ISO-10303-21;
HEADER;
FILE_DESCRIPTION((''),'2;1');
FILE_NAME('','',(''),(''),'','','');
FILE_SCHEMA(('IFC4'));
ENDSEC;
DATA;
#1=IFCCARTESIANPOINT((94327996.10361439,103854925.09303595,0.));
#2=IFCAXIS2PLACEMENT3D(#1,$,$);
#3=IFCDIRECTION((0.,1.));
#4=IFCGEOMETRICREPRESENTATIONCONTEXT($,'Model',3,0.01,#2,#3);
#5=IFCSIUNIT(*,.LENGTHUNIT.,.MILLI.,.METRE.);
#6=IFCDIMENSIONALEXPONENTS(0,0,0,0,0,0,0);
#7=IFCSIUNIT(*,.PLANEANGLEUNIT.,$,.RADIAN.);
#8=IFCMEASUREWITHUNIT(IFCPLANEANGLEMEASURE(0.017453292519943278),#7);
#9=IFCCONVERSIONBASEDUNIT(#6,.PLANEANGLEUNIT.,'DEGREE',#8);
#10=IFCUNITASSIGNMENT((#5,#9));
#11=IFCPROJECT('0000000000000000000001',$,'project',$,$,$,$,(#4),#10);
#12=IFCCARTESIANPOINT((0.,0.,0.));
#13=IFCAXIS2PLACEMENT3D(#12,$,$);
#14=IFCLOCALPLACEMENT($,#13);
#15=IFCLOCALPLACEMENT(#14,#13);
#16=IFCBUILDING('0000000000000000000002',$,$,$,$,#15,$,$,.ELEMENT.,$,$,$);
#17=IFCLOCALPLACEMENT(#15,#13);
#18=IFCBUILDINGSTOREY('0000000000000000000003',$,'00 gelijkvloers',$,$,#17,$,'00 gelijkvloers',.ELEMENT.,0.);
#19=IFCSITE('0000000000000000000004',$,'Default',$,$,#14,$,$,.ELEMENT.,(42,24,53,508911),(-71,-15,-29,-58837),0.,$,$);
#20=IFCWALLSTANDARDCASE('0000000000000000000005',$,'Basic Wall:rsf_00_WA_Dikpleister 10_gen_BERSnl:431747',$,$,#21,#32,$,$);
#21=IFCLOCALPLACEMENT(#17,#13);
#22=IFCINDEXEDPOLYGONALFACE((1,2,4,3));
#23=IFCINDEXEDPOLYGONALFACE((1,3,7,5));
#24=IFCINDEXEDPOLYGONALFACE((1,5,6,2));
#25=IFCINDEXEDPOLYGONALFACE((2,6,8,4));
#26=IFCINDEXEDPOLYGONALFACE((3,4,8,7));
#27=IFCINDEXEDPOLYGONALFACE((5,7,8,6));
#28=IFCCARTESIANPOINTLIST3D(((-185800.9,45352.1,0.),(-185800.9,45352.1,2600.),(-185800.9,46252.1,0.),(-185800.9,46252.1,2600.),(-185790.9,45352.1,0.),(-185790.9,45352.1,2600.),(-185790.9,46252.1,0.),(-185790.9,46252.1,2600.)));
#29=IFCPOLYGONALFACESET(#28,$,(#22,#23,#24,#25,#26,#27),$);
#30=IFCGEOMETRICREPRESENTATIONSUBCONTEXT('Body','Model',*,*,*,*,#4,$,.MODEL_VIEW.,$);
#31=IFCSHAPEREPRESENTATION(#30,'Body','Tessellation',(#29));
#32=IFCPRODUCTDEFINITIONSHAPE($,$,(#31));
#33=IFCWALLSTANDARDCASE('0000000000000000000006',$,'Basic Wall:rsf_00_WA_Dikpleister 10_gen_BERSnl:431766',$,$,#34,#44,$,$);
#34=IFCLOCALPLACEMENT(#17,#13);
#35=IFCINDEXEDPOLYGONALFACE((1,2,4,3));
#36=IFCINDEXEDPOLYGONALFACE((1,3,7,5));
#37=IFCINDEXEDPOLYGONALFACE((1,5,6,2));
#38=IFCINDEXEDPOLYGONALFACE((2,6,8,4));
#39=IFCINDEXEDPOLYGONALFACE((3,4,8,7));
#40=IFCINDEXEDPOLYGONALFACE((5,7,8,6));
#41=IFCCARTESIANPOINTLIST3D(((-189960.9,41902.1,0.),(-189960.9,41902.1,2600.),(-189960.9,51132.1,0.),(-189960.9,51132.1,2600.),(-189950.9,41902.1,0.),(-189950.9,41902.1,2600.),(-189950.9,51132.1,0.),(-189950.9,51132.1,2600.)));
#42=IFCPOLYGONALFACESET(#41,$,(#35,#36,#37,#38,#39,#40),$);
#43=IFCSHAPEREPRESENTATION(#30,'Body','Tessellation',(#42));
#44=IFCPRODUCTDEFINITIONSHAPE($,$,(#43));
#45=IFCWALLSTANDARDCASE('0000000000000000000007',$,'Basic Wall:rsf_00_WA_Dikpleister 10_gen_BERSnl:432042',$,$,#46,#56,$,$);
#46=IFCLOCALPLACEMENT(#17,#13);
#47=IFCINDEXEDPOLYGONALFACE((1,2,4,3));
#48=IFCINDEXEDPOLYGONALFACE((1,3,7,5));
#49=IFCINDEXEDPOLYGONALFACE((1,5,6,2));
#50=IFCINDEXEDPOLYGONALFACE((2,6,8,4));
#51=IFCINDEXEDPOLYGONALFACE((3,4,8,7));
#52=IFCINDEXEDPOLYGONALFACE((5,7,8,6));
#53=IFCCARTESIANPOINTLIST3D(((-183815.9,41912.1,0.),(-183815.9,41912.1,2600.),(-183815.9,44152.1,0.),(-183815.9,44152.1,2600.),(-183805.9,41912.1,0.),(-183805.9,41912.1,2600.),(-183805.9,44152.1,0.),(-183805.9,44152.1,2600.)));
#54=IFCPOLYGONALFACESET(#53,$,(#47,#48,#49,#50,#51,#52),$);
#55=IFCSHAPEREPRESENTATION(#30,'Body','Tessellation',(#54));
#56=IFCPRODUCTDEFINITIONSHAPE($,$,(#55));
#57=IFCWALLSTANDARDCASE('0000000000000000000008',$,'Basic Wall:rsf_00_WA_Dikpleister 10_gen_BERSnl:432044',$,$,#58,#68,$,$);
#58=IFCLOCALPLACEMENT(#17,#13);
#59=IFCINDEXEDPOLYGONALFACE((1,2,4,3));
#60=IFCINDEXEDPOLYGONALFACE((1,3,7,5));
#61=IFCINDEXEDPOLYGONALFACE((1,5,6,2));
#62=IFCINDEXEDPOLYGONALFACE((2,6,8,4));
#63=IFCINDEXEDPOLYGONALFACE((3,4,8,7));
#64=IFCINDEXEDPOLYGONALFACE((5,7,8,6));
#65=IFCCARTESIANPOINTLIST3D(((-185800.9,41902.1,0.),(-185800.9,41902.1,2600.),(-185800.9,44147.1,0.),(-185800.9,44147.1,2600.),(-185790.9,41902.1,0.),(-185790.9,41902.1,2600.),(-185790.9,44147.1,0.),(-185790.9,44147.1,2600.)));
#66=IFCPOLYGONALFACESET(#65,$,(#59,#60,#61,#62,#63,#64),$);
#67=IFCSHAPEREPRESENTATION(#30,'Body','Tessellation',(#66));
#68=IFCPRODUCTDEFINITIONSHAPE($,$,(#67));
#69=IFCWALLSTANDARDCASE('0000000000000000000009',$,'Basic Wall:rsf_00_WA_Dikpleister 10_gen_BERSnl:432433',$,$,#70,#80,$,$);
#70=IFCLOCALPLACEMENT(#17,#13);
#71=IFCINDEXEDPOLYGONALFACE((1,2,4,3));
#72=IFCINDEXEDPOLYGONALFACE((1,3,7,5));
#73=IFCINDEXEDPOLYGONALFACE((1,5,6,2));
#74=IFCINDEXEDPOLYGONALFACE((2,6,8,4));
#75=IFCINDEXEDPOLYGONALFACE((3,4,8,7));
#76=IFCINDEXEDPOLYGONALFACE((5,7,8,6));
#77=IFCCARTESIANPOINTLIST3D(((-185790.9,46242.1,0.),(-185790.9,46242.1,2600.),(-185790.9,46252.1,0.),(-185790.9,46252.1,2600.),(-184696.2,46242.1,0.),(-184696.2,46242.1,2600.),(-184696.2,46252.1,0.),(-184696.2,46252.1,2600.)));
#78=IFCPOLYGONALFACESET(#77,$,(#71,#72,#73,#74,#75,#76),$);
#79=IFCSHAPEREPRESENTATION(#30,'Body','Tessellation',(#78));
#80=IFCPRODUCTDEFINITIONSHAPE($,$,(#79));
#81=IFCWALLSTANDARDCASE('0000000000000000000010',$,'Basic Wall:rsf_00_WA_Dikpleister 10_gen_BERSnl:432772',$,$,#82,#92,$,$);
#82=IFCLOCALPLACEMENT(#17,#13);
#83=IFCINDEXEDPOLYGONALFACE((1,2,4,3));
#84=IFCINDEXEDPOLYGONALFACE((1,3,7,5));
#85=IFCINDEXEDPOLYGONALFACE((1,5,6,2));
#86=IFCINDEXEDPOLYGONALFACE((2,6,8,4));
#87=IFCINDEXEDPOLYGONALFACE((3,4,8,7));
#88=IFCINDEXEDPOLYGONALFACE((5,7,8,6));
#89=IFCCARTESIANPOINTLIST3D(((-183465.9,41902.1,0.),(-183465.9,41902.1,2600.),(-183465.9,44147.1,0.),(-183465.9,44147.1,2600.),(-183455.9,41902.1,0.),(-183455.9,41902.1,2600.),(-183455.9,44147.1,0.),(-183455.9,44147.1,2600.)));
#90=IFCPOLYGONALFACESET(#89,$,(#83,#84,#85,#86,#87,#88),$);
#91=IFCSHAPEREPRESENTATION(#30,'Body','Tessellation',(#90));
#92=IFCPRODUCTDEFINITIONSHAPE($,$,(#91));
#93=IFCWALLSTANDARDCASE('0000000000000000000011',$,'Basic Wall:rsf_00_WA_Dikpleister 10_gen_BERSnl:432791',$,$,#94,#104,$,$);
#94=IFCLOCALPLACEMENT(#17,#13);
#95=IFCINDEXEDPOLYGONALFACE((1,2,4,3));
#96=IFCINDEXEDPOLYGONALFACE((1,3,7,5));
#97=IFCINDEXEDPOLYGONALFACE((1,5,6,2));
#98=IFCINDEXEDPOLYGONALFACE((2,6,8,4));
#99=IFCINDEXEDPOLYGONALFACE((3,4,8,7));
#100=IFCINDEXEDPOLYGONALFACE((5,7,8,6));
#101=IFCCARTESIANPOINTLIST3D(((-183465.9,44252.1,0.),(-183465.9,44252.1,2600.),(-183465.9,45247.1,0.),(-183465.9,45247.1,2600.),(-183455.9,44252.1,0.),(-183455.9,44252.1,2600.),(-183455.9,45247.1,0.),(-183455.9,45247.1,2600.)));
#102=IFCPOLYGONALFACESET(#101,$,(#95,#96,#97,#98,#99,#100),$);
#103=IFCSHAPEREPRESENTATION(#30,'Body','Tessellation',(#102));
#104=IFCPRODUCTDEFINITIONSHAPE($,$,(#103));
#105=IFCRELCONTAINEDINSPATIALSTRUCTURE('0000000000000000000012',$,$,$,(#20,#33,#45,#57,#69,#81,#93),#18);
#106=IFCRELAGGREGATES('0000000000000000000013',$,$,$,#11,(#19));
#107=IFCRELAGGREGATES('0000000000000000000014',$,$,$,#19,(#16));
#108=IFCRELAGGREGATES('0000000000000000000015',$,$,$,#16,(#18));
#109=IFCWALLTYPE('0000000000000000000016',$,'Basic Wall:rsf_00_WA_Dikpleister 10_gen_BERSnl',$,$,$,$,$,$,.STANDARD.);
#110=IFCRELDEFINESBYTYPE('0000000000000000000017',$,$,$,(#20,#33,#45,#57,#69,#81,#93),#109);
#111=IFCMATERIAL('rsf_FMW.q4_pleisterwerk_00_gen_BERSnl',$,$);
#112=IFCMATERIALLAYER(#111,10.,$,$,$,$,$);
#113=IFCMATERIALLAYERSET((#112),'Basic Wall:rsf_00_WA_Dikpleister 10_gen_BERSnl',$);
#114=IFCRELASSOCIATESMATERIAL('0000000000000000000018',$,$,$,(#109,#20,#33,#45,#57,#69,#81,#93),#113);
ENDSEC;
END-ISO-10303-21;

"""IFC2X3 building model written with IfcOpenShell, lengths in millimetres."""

from ifc_helpers import new_model, entity, si_unit, converted_unit, direction, frame, frame_2d, origin, place, context, subcontext, project, spatial, rectangle, extrude, material, layer, layer_set, layer_usage, type_object, element, save


model = new_model("IFC2X3")

# Units and contexts
model_context = context("Model", 3, precision=0.01, world=frame((94327996.10361439, 103854925.09303595, 0.0)), true_north=direction((0.0, 1.0)))
body_context = subcontext(model_context, "Body", "Model", "MODEL_VIEW")
ifc_project = project(units=[si_unit("LENGTHUNIT", "METRE", prefix="MILLI"), converted_unit("PLANEANGLEUNIT", "DEGREE", entity("IfcPlaneAngleMeasure", 0.017453292519943278), si_unit("PLANEANGLEUNIT", "RADIAN"), dimensions=[0, 0, 0, 0, 0, 0, 0])], contexts=[model_context])

# Site, building, storey
site_placement = place(None, origin())
site = spatial("IfcSite", under=ifc_project, at=site_placement, Name="Default", CompositionType="ELEMENT", RefLatitude=(42, 24, 53, 508911), RefLongitude=(-71, -15, -29, -58837), RefElevation=0.0)
building_placement = place(site_placement, origin())
building = spatial("IfcBuilding", under=site, at=building_placement, CompositionType="ELEMENT")
storey_placement = place(building_placement, origin())
storey = spatial("IfcBuildingStorey", under=building, at=storey_placement, Name="00 gelijkvloers", LongName="00 gelijkvloers", CompositionType="ELEMENT", Elevation=0.0)

# Shared definitions
ifc_material_1 = material(Name="rsf_FMW.q4_pleisterwerk_00_gen_BERSnl")

# Walls
ifc_layer_1 = layer(ifc_material_1, 10.0)
ifc_layer_set_1 = layer_set([ifc_layer_1], Name="Basic Wall:rsf_00_WA_Dikpleister 10_gen_BERSnl")
wall_type_1 = type_object("IfcWallType", Name="Basic Wall:rsf_00_WA_Dikpleister 10_gen_BERSnl", PredefinedType="STANDARD", material=ifc_layer_set_1)
ifc_layer_usage_1 = layer_usage(ifc_layer_set_1, "AXIS2", "POSITIVE", -5.0)
wall_1_placement = place(storey_placement, frame((-185795.9, 45352.1, 0.0), z_axis=(0.0, 0.0, 1.0), x_axis=(0.0, 1.0, 0.0)))
element("IfcWallStandardCase", 1, at=wall_1_placement, inside=storey, type_object=wall_type_1, material=ifc_layer_usage_1, Name="Basic Wall:rsf_00_WA_Dikpleister 10_gen_BERSnl:431747", context=body_context, shape_type="SweptSolid", body=[
    extrude(rectangle(XDim=900.0, YDim=10.0, at=frame_2d((450.0, 0.0), x_axis=(-1.0, 0.0))), origin(), (0.0, 0.0, 1.0), 2600.0),
])
ifc_layer_usage_2 = layer_usage(ifc_layer_set_1, "AXIS2", "POSITIVE", -5.0)
wall_2_placement = place(storey_placement, frame((-189955.9, 41902.1, 0.0), z_axis=(0.0, 0.0, 1.0), x_axis=(0.0, 1.0, 0.0)))
element("IfcWallStandardCase", 2, at=wall_2_placement, inside=storey, type_object=wall_type_1, material=ifc_layer_usage_2, Name="Basic Wall:rsf_00_WA_Dikpleister 10_gen_BERSnl:431766", context=body_context, shape_type="SweptSolid", body=[
    extrude(rectangle(XDim=9230.0, YDim=10.0, at=frame_2d((4615.0, 0.0), x_axis=(-1.0, 0.0))), origin(), (0.0, 0.0, 1.0), 2600.0),
])
ifc_layer_usage_3 = layer_usage(ifc_layer_set_1, "AXIS2", "POSITIVE", -5.0)
wall_3_placement = place(storey_placement, frame((-183810.9, 44152.1, 0.0), z_axis=(0.0, 0.0, 1.0), x_axis=(0.0, -1.0, 0.0)))
element("IfcWallStandardCase", 3, at=wall_3_placement, inside=storey, type_object=wall_type_1, material=ifc_layer_usage_3, Name="Basic Wall:rsf_00_WA_Dikpleister 10_gen_BERSnl:432042", context=body_context, shape_type="SweptSolid", body=[
    extrude(rectangle(XDim=2240.0, YDim=10.0, at=frame_2d((1120.0, 0.0), x_axis=(-1.0, 0.0))), origin(), (0.0, 0.0, 1.0), 2600.0),
])
ifc_layer_usage_4 = layer_usage(ifc_layer_set_1, "AXIS2", "POSITIVE", -5.0)
wall_4_placement = place(storey_placement, frame((-185795.9, 41902.1, 0.0), z_axis=(0.0, 0.0, 1.0), x_axis=(0.0, 1.0, 0.0)))
element("IfcWallStandardCase", 4, at=wall_4_placement, inside=storey, type_object=wall_type_1, material=ifc_layer_usage_4, Name="Basic Wall:rsf_00_WA_Dikpleister 10_gen_BERSnl:432044", context=body_context, shape_type="SweptSolid", body=[
    extrude(rectangle(XDim=2245.0, YDim=10.0, at=frame_2d((1122.5, 0.0), x_axis=(-1.0, 0.0))), origin(), (0.0, 0.0, 1.0), 2600.0),
])
ifc_layer_usage_5 = layer_usage(ifc_layer_set_1, "AXIS2", "POSITIVE", -5.0)
wall_5_placement = place(storey_placement, frame((-185790.9, 46247.1, 0.0)))
element("IfcWallStandardCase", 5, at=wall_5_placement, inside=storey, type_object=wall_type_1, material=ifc_layer_usage_5, Name="Basic Wall:rsf_00_WA_Dikpleister 10_gen_BERSnl:432433", context=body_context, shape_type="SweptSolid", body=[
    extrude(rectangle(XDim=1094.6, YDim=10.0, at=frame_2d((547.3, 0.0), x_axis=(-1.0, 0.0))), origin(), (0.0, 0.0, 1.0), 2600.0),
])
ifc_layer_usage_6 = layer_usage(ifc_layer_set_1, "AXIS2", "POSITIVE", -5.0)
wall_6_placement = place(storey_placement, frame((-183460.9, 41902.1, 0.0), z_axis=(0.0, 0.0, 1.0), x_axis=(0.0, 1.0, 0.0)))
element("IfcWallStandardCase", 6, at=wall_6_placement, inside=storey, type_object=wall_type_1, material=ifc_layer_usage_6, Name="Basic Wall:rsf_00_WA_Dikpleister 10_gen_BERSnl:432772", context=body_context, shape_type="SweptSolid", body=[
    extrude(rectangle(XDim=2245.0, YDim=10.0, at=frame_2d((1122.5, 0.0), x_axis=(-1.0, 0.0))), origin(), (0.0, 0.0, 1.0), 2600.0),
])
ifc_layer_usage_7 = layer_usage(ifc_layer_set_1, "AXIS2", "POSITIVE", -5.0)
wall_7_placement = place(storey_placement, frame((-183460.9, 44252.1, 0.0), z_axis=(0.0, 0.0, 1.0), x_axis=(0.0, 1.0, 0.0)))
element("IfcWallStandardCase", 7, at=wall_7_placement, inside=storey, type_object=wall_type_1, material=ifc_layer_usage_7, Name="Basic Wall:rsf_00_WA_Dikpleister 10_gen_BERSnl:432791", context=body_context, shape_type="SweptSolid", body=[
    extrude(rectangle(XDim=995.0, YDim=10.0, at=frame_2d((497.5, 0.0), x_axis=(-1.0, 0.0))), origin(), (0.0, 0.0, 1.0), 2600.0),
])

save(model, "model.ifc")
